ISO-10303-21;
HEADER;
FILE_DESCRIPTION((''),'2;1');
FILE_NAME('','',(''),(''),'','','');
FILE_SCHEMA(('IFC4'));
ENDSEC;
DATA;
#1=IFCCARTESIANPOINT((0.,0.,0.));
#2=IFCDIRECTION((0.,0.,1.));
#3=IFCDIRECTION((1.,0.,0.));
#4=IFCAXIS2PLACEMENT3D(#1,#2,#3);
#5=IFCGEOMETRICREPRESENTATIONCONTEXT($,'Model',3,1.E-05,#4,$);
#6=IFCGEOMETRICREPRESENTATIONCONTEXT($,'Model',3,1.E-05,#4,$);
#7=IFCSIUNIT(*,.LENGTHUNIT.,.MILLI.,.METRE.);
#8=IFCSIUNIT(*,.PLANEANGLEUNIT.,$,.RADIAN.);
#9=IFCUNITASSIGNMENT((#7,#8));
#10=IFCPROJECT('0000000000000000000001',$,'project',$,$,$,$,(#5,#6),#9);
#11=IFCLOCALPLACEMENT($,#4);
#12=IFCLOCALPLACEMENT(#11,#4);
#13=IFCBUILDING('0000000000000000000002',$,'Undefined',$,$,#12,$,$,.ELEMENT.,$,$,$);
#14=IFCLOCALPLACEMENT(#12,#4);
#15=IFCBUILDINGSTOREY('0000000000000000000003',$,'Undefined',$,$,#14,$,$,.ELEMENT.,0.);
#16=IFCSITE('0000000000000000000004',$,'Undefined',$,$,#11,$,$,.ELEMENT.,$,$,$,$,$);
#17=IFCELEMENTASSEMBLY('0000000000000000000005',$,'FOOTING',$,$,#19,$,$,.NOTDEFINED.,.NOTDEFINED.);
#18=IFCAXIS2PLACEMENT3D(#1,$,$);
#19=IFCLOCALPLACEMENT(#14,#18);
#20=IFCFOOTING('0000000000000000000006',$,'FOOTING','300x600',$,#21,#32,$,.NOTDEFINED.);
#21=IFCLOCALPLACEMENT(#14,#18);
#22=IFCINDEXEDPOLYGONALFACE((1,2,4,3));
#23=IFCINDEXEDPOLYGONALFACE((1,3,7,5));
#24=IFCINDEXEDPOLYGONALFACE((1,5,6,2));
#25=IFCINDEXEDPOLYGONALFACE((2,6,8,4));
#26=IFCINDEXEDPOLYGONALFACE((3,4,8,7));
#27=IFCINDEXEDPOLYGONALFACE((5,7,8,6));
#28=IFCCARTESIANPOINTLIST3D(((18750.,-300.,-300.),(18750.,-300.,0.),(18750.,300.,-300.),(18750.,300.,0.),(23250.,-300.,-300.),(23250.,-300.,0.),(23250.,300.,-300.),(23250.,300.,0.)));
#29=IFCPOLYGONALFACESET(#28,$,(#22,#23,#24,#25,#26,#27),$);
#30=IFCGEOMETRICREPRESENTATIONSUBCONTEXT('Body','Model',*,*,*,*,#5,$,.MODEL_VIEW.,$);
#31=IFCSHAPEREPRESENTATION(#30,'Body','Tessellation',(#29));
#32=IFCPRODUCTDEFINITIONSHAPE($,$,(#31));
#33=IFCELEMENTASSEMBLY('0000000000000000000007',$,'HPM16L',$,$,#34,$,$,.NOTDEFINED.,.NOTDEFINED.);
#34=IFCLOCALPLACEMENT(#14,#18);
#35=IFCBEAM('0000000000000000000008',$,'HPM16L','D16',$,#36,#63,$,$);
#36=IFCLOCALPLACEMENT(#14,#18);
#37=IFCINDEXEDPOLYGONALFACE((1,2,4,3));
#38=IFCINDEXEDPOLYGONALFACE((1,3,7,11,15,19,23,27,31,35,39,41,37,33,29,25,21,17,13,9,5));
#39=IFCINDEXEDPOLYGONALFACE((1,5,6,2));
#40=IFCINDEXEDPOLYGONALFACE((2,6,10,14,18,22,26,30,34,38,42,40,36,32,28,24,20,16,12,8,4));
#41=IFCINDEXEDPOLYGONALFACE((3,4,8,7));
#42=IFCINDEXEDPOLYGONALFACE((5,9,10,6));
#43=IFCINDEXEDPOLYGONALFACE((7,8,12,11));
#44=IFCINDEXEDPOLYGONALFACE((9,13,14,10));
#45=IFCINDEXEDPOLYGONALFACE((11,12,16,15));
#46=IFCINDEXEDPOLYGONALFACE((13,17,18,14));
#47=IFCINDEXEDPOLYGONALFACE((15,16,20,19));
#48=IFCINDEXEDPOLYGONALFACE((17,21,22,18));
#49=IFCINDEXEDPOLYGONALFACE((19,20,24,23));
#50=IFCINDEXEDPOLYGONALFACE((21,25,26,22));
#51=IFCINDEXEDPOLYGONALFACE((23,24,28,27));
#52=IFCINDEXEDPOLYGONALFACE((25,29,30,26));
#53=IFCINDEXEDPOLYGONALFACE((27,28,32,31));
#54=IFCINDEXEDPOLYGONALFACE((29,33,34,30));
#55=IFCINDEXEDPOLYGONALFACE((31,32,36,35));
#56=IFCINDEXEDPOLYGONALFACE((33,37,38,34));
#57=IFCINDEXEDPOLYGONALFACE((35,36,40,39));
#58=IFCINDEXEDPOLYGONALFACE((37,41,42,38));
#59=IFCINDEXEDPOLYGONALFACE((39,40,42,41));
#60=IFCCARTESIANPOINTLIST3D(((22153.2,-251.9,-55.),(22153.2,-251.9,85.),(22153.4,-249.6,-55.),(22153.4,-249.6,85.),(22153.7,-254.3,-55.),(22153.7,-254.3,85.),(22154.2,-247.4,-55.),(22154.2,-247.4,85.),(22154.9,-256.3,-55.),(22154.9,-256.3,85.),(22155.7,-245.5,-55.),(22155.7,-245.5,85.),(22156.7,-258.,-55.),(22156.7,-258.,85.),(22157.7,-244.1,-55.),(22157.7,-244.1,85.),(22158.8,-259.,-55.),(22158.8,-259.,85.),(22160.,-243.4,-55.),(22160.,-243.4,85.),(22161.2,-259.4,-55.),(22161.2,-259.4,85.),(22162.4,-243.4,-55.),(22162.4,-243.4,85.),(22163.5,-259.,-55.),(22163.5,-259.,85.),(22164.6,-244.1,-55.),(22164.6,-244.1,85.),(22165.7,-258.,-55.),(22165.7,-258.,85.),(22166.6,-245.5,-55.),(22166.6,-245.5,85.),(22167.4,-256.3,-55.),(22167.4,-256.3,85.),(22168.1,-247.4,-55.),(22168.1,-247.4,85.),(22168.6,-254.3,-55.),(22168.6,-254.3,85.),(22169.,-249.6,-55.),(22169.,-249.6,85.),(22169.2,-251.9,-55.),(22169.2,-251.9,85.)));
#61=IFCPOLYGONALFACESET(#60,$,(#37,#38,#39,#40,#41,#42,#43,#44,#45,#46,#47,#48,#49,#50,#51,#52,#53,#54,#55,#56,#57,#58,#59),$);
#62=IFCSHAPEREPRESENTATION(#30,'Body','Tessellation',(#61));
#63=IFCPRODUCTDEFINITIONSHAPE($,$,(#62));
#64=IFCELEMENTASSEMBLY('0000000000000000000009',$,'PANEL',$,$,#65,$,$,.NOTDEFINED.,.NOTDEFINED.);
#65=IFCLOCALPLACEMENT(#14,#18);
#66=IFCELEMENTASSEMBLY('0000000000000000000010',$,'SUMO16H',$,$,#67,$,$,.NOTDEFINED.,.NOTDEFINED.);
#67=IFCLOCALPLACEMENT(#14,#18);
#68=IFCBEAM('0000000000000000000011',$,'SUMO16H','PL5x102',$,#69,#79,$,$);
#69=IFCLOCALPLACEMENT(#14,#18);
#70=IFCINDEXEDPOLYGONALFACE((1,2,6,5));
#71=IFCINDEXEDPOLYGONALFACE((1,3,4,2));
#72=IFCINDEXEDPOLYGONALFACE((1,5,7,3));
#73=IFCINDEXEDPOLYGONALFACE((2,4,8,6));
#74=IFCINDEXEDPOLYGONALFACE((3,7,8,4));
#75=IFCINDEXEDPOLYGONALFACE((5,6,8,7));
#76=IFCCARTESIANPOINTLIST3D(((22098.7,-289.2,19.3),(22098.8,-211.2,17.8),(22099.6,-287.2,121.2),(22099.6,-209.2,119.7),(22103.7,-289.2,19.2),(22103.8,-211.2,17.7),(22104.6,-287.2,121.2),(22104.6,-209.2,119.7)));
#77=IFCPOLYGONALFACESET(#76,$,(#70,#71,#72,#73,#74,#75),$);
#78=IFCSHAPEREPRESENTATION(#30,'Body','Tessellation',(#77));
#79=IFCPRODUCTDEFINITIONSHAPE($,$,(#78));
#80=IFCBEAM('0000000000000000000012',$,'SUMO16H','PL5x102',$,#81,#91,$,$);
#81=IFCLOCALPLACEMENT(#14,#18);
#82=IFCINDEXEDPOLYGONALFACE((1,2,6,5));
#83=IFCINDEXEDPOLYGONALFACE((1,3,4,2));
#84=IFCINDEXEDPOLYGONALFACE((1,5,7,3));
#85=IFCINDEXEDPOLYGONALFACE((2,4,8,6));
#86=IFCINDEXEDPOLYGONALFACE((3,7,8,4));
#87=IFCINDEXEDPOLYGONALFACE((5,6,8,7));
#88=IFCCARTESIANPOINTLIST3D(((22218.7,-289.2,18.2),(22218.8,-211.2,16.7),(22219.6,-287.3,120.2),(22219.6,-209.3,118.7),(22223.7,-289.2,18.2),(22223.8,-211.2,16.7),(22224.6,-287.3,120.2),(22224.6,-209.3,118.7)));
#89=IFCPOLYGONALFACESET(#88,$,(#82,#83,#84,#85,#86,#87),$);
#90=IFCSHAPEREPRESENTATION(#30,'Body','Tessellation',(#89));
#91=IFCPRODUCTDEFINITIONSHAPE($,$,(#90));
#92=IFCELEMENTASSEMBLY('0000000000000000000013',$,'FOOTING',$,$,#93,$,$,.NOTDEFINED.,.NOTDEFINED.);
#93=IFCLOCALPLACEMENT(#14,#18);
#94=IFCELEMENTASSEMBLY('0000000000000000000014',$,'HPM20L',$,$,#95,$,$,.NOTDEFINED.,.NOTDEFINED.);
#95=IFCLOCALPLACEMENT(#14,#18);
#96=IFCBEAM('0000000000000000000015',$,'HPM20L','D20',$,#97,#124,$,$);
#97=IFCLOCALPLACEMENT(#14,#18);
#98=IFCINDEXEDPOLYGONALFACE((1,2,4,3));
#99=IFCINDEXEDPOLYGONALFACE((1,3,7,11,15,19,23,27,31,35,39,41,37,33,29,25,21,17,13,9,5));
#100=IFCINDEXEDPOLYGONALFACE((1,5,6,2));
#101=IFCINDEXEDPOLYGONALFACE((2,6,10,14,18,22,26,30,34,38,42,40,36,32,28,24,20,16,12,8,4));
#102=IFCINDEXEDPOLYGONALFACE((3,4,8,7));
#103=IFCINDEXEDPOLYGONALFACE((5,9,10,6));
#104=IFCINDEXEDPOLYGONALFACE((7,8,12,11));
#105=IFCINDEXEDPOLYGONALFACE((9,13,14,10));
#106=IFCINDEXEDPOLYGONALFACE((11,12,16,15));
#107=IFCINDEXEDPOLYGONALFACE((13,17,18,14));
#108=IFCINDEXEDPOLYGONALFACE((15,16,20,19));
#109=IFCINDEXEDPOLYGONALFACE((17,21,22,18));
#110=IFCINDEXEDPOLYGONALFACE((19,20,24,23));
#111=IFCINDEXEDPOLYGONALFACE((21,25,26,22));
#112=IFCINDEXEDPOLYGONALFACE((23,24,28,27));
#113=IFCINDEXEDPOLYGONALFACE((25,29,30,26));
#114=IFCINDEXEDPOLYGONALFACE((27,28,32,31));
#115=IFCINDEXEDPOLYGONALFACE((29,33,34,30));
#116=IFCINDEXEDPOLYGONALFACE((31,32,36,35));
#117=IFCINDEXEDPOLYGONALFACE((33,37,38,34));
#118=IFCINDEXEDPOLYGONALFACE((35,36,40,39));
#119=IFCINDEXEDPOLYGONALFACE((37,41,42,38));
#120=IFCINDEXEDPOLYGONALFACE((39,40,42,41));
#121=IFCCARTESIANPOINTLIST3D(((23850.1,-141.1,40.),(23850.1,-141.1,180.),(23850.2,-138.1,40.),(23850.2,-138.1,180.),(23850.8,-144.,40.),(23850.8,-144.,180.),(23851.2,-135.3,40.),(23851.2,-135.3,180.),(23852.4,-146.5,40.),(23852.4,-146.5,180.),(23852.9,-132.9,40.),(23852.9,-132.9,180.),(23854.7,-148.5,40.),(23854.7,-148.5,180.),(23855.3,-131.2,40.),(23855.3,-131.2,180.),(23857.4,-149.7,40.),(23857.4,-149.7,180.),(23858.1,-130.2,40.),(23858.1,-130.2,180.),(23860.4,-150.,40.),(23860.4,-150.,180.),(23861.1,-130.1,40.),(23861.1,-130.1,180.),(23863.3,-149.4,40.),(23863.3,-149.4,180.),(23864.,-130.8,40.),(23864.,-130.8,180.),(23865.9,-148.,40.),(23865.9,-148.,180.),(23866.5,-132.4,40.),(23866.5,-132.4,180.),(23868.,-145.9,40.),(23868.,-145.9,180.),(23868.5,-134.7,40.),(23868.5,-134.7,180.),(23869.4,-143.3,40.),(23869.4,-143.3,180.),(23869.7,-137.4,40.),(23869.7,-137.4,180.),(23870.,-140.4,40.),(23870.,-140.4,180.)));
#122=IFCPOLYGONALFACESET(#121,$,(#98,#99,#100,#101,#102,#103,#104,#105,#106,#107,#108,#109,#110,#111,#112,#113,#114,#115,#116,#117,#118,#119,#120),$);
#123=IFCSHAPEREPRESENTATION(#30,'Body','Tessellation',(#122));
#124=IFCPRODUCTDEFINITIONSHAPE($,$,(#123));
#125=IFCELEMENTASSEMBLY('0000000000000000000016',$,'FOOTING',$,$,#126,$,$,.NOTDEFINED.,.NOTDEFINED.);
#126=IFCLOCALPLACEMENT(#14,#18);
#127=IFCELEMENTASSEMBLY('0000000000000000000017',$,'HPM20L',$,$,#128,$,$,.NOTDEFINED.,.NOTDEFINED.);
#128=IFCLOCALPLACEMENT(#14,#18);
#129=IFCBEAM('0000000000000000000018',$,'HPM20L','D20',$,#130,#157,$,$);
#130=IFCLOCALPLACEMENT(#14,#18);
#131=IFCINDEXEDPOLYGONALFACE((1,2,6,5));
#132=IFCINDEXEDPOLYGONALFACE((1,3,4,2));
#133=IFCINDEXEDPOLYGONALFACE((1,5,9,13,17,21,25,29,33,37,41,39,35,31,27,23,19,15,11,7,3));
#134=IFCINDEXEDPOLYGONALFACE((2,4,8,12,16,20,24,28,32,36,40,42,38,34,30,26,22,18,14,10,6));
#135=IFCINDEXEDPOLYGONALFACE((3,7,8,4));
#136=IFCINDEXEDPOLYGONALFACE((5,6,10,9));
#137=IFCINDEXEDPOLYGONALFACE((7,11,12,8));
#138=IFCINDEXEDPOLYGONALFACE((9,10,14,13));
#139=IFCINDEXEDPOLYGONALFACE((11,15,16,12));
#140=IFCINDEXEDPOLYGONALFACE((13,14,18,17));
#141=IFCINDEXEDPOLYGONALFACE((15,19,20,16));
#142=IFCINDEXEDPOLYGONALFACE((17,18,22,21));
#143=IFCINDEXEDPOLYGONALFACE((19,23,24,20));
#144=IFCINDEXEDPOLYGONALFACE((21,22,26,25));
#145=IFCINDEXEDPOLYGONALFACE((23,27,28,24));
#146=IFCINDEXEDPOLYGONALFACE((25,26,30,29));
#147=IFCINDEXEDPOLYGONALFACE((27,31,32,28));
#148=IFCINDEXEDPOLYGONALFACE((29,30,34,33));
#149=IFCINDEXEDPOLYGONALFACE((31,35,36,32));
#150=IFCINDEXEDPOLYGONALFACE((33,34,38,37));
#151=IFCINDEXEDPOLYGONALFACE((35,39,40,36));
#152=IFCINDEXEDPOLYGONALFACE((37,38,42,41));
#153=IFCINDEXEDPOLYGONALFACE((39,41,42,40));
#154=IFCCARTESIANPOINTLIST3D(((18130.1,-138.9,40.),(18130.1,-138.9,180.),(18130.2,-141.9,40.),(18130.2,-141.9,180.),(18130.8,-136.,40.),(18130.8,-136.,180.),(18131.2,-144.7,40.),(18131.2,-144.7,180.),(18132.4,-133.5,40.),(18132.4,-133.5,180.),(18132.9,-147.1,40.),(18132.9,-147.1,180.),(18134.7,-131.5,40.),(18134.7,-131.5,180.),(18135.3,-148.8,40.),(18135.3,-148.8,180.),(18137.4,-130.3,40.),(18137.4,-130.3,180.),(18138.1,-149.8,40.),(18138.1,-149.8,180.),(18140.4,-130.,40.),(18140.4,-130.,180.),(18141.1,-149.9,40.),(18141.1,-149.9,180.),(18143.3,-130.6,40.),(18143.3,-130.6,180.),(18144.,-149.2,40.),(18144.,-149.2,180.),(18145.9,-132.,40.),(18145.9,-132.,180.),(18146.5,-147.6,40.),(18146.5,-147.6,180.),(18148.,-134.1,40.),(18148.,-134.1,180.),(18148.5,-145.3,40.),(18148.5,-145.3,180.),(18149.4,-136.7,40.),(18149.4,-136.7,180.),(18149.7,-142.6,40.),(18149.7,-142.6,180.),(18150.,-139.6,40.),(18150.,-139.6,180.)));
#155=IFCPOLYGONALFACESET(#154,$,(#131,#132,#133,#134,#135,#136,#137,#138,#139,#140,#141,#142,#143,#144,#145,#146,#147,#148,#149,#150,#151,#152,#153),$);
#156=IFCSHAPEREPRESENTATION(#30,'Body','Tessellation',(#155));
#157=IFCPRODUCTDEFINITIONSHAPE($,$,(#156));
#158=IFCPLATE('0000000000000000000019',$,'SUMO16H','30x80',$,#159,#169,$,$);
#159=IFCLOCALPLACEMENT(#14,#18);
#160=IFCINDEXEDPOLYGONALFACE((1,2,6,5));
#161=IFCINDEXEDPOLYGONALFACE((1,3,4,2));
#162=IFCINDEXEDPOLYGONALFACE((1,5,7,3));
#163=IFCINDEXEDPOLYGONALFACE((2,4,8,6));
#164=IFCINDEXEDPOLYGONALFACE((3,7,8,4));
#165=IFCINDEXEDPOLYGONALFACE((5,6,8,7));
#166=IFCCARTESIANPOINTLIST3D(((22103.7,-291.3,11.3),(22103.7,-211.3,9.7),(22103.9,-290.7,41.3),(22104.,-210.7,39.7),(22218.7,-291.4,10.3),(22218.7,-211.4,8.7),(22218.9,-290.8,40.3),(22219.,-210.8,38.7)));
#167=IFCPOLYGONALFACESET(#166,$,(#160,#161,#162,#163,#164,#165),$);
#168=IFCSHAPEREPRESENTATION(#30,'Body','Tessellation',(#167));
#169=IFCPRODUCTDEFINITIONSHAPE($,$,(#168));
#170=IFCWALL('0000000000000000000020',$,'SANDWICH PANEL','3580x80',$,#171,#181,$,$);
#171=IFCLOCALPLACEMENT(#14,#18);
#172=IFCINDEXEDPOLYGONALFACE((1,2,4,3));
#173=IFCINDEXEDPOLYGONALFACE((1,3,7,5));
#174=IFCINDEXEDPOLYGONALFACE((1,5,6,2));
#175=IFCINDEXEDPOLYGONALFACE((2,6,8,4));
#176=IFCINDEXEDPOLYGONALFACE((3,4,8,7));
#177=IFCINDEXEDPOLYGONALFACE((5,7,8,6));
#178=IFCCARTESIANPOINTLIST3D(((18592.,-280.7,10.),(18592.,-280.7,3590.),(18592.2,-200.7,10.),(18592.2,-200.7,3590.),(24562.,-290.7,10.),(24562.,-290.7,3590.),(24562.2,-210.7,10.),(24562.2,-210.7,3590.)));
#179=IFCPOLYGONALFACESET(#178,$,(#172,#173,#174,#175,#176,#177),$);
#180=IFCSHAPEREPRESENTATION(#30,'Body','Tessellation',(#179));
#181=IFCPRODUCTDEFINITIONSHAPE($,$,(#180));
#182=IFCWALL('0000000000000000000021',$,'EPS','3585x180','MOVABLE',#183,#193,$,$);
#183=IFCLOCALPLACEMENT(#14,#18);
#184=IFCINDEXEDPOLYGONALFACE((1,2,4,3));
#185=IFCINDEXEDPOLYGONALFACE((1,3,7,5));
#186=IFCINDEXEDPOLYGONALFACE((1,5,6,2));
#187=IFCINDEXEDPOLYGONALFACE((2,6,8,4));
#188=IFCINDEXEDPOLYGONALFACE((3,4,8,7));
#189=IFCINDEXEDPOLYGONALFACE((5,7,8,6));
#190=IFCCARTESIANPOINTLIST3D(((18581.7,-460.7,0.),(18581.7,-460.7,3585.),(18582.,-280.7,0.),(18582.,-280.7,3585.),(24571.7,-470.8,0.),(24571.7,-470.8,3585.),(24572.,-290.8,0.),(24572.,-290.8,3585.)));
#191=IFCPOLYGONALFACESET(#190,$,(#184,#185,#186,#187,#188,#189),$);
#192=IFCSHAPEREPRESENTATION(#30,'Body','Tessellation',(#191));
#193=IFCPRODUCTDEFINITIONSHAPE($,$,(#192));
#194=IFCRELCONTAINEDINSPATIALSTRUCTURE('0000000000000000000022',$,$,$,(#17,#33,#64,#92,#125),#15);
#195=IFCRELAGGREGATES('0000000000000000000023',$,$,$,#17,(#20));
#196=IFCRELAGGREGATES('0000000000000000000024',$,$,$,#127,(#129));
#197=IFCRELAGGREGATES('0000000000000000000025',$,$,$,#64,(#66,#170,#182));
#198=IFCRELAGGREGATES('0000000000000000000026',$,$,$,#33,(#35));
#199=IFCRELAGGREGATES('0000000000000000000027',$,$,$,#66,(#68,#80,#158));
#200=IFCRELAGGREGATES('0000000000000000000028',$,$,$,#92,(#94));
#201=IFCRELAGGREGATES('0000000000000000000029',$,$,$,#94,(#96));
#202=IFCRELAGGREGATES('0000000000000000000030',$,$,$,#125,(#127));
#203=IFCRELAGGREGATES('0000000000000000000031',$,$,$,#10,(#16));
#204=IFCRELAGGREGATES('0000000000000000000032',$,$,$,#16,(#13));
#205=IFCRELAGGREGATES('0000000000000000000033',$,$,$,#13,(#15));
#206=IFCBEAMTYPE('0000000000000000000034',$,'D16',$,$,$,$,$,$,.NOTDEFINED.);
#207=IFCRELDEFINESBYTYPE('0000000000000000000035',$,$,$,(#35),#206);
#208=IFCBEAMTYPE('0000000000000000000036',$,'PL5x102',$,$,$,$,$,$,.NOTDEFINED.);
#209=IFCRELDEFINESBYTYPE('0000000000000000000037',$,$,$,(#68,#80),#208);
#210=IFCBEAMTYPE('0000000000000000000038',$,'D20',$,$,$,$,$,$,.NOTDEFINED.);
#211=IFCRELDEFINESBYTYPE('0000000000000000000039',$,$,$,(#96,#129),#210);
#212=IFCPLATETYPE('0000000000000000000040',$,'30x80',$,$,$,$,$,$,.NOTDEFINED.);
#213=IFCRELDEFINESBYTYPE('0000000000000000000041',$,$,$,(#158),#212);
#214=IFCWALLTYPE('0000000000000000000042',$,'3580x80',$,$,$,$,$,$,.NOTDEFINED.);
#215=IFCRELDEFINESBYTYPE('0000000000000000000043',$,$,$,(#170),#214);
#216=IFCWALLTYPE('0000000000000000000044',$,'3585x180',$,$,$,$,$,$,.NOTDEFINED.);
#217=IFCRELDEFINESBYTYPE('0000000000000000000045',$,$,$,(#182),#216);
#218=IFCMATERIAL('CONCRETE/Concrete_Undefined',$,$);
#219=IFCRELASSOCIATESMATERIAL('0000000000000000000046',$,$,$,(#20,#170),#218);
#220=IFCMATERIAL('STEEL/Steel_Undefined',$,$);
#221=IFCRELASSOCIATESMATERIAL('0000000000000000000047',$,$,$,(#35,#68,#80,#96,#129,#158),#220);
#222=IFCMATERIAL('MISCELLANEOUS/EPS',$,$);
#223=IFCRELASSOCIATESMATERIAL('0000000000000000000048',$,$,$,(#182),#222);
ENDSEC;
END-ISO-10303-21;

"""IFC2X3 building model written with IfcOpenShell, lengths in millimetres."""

from ifc_helpers import new_model, si_unit, frame, frame_2d, origin_with_axes, origin_2d_with_axis, place, context, subcontext, project, spatial, polyline, rectangle, circle, outline, extrude, material, type_object, element, aggregate, save


model = new_model("IFC2X3")

# Units and contexts
model_context_1 = context("Model", 3, precision=1e-05, world=origin_with_axes())
model_context_2 = context("Model", 3, precision=1e-05, world=origin_with_axes())
body_context = subcontext(model_context_1, "Body", "Model", "MODEL_VIEW")
ifc_project = project(units=[si_unit("LENGTHUNIT", "METRE", prefix="MILLI"), si_unit("PLANEANGLEUNIT", "RADIAN")], contexts=[model_context_1, model_context_2])

# Site, building, storey
site_placement = place(None, origin_with_axes())
site = spatial("IfcSite", under=ifc_project, at=site_placement, Name="Undefined", CompositionType="ELEMENT")
building_placement = place(site_placement, origin_with_axes())
building = spatial("IfcBuilding", under=site, at=building_placement, Name="Undefined", CompositionType="ELEMENT")
storey_placement = place(building_placement, origin_with_axes())
storey = spatial("IfcBuildingStorey", under=building, at=storey_placement, Name="Undefined", CompositionType="ELEMENT", Elevation=0.0)

# Element assembly, footing
assembly_1_placement = place(storey_placement, origin_with_axes())
assembly_1 = element("IfcElementAssembly", 1, at=assembly_1_placement, inside=storey, Name="FOOTING", AssemblyPlace="NOTDEFINED", PredefinedType="NOTDEFINED")
ifc_material_1 = material(Name="CONCRETE/Concrete_Undefined")
footing_placement = place(assembly_1_placement, frame((18750.0, 0.0, -150.0), z_axis=(0.0, 0.0, 1.0), x_axis=(1.0, 0.0, 0.0)))
footing = element("IfcFooting", 2, at=footing_placement, material=ifc_material_1, Name="FOOTING", Description="300x600", PredefinedType="NOTDEFINED", context=body_context, shape_type="SweptSolid", body=[
    extrude(rectangle(XDim=600.0, YDim=300.0, at=origin_2d_with_axis()), frame((4500.0, 0.0, 0.0), z_axis=(-1.0, 0.0, 0.0), x_axis=(0.0, -1.0, 0.0)), (0.0, 0.0, 1.0), 4500.0),
])
aggregate(assembly_1, [footing])

# Element assembly, beam
assembly_2_placement = place(storey_placement, origin_with_axes())
assembly_2 = element("IfcElementAssembly", 3, at=assembly_2_placement, inside=storey, Name="HPM16L", AssemblyPlace="NOTDEFINED", PredefinedType="NOTDEFINED")
ifc_material_2 = material(Name="STEEL/Steel_Undefined")
beam_type_1 = type_object("IfcBeamType", Name="D16", PredefinedType="NOTDEFINED")
beam_1_placement = place(assembly_2_placement, frame((22161.2, -251.4, 85.0), z_axis=(1.0, 0.0, 0.0), x_axis=(0.0, 0.0, -1.0)))
beam_1 = element("IfcBeam", 4, at=beam_1_placement, type_object=beam_type_1, material=ifc_material_2, Name="HPM16L", Description="D16", context=body_context, shape_type="SweptSolid", body=[
    extrude(circle(Radius=8.0, at=origin_2d_with_axis()), frame((140.0, 0.0, 0.0), z_axis=(-1.0, 0.0, 0.0), x_axis=(0.0, -1.0, 0.0)), (0.0, 0.0, 1.0), 140.0),
])

# Element assemblies, beams
assembly_3_placement = place(storey_placement, origin_with_axes())
assembly_3 = element("IfcElementAssembly", 5, at=assembly_3_placement, inside=storey, Name="PANEL", AssemblyPlace="NOTDEFINED", PredefinedType="NOTDEFINED")
assembly_4_placement = place(assembly_3_placement, origin_with_axes())
assembly_4 = element("IfcElementAssembly", 6, at=assembly_4_placement, Name="SUMO16H", AssemblyPlace="NOTDEFINED", PredefinedType="NOTDEFINED")
beam_type_2 = type_object("IfcBeamType", Name="PL5x102", PredefinedType="NOTDEFINED")
beam_2_placement = place(assembly_4_placement, frame((22101.7, -210.2, 68.7), z_axis=(0.008618, 0.019092, 0.999781), x_axis=(-0.000494, -0.999818, 0.019097)))
beam_2 = element("IfcBeam", 7, at=beam_2_placement, type_object=beam_type_2, material=ifc_material_2, Name="SUMO16H", Description="PL5x102", context=body_context, shape_type="SweptSolid", body=[
    extrude(rectangle(XDim=5.0, YDim=102.0, at=origin_2d_with_axis()), frame((78.0, 0.0, 0.0), z_axis=(-1.0, 0.0, 0.0), x_axis=(0.0, -1.0, 0.0)), (0.0, 0.0, 1.0), 78.0),
])
beam_3_placement = place(assembly_4_placement, frame((22221.7, -210.3, 67.7), z_axis=(0.008618, 0.019092, 0.999781), x_axis=(-0.000494, -0.999818, 0.019097)))
beam_3 = element("IfcBeam", 8, at=beam_3_placement, type_object=beam_type_2, material=ifc_material_2, Name="SUMO16H", Description="PL5x102", context=body_context, shape_type="SweptSolid", body=[
    extrude(rectangle(XDim=5.0, YDim=102.0, at=origin_2d_with_axis()), frame((78.0, 0.0, 0.0), z_axis=(-1.0, 0.0, 0.0), x_axis=(0.0, -1.0, 0.0)), (0.0, 0.0, 1.0), 78.0),
])

# Element assemblies, beams
assembly_5_placement = place(storey_placement, origin_with_axes())
assembly_5 = element("IfcElementAssembly", 9, at=assembly_5_placement, inside=storey, Name="FOOTING", AssemblyPlace="NOTDEFINED", PredefinedType="NOTDEFINED")
assembly_6_placement = place(assembly_5_placement, origin_with_axes())
assembly_6 = element("IfcElementAssembly", 10, at=assembly_6_placement, Name="HPM20L", AssemblyPlace="NOTDEFINED", PredefinedType="NOTDEFINED")
beam_type_3 = type_object("IfcBeamType", Name="D20", PredefinedType="NOTDEFINED")
beam_4_placement = place(assembly_6_placement, frame((23860.0, -140.0, 180.0), z_axis=(-0.707107, -0.707107, 0.0), x_axis=(0.0, 0.0, -1.0)))
beam_4 = element("IfcBeam", 11, at=beam_4_placement, type_object=beam_type_3, material=ifc_material_2, Name="HPM20L", Description="D20", context=body_context, shape_type="SweptSolid", body=[
    extrude(circle(Radius=10.0, at=origin_2d_with_axis()), frame((140.0, 0.0, 0.0), z_axis=(-1.0, 0.0, 0.0), x_axis=(0.0, -1.0, 0.0)), (0.0, 0.0, 1.0), 140.0),
])
assembly_7_placement = place(storey_placement, origin_with_axes())
assembly_7 = element("IfcElementAssembly", 12, at=assembly_7_placement, inside=storey, Name="FOOTING", AssemblyPlace="NOTDEFINED", PredefinedType="NOTDEFINED")
assembly_8_placement = place(assembly_7_placement, origin_with_axes())
assembly_8 = element("IfcElementAssembly", 13, at=assembly_8_placement, Name="HPM20L", AssemblyPlace="NOTDEFINED", PredefinedType="NOTDEFINED")
beam_5_placement = place(assembly_8_placement, frame((18140.0, -140.0, 180.0), z_axis=(0.707107, -0.707107, 0.0), x_axis=(0.0, 0.0, -1.0)))
beam_5 = element("IfcBeam", 14, at=beam_5_placement, type_object=beam_type_3, material=ifc_material_2, Name="HPM20L", Description="D20", context=body_context, shape_type="SweptSolid", body=[
    extrude(circle(Radius=10.0, at=origin_2d_with_axis()), frame((140.0, 0.0, 0.0), z_axis=(-1.0, 0.0, 0.0), x_axis=(0.0, -1.0, 0.0)), (0.0, 0.0, 1.0), 140.0),
])
aggregate(assembly_8, [beam_5])

# Plate
plate_type = type_object("IfcPlateType", Name="30x80", PredefinedType="NOTDEFINED")
plate_placement = place(assembly_4_placement, frame((22218.8, -211.1, 23.7), z_axis=(0.008618, 0.019092, 0.999781), x_axis=(-0.999963, 0.000658, 0.008607)))
plate = element("IfcPlate", 15, at=plate_placement, type_object=plate_type, material=ifc_material_2, Name="SUMO16H", Description="30x80", context=body_context, shape_type="SweptSolid", body=[
    extrude(outline(polyline([(0.0, 0.0), (115.0, 0.0), (115.0, 80.0), (0.0, 80.0), (0.0, 0.0)])), frame((0.0, 0.0, -15.0), z_axis=(0.0, 0.0, 1.0), x_axis=(1.0, 0.0, 0.0)), (0.0, 0.0, 1.0), 30.0),
])

# Walls
wall_type_1 = type_object("IfcWallType", Name="3580x80", PredefinedType="NOTDEFINED")
wall_1_placement = place(assembly_3_placement, frame((18592.1, -240.7, 10.0), z_axis=(0.0, 0.0, 1.0), x_axis=(0.999999, -0.001684, 0.0)))
wall_1 = element("IfcWall", 16, at=wall_1_placement, type_object=wall_type_1, material=ifc_material_1, Name="SANDWICH PANEL", Description="3580x80", context=body_context, shape_type="SweptSolid", body=[
    extrude(rectangle(XDim=5970.0, YDim=80.0, at=frame_2d((0.0, 2985.0), x_axis=(0.0, -1.0))), frame((0.0, 0.0, 0.0), z_axis=(0.0, 0.0, 1.0), x_axis=(0.0, -1.0, 0.0)), (0.0, 0.0, 1.0), 3580.0),
])
ifc_material_3 = material(Name="MISCELLANEOUS/EPS")
wall_type_2 = type_object("IfcWallType", Name="3585x180", PredefinedType="NOTDEFINED")
wall_2_placement = place(assembly_3_placement, frame((18581.9, -370.7, 0.0), z_axis=(0.0, 0.0, 1.0), x_axis=(0.999999, -0.001684, 0.0)))
wall_2 = element("IfcWall", 17, at=wall_2_placement, type_object=wall_type_2, material=ifc_material_3, Name="EPS", Description="3585x180", ObjectType="MOVABLE", context=body_context, shape_type="SweptSolid", body=[
    extrude(rectangle(XDim=5990.0, YDim=180.0, at=frame_2d((0.0, 2995.0), x_axis=(0.0, -1.0))), frame((0.0, 0.0, 0.0), z_axis=(0.0, 0.0, 1.0), x_axis=(0.0, -1.0, 0.0)), (0.0, 0.0, 1.0), 3585.0),
])
aggregate(assembly_3, [assembly_4, wall_1, wall_2])

aggregate(assembly_2, [beam_1])

aggregate(assembly_4, [beam_2, beam_3, plate])

aggregate(assembly_5, [assembly_6])

aggregate(assembly_6, [beam_4])

aggregate(assembly_7, [assembly_8])

save(model, "model.ifc")
